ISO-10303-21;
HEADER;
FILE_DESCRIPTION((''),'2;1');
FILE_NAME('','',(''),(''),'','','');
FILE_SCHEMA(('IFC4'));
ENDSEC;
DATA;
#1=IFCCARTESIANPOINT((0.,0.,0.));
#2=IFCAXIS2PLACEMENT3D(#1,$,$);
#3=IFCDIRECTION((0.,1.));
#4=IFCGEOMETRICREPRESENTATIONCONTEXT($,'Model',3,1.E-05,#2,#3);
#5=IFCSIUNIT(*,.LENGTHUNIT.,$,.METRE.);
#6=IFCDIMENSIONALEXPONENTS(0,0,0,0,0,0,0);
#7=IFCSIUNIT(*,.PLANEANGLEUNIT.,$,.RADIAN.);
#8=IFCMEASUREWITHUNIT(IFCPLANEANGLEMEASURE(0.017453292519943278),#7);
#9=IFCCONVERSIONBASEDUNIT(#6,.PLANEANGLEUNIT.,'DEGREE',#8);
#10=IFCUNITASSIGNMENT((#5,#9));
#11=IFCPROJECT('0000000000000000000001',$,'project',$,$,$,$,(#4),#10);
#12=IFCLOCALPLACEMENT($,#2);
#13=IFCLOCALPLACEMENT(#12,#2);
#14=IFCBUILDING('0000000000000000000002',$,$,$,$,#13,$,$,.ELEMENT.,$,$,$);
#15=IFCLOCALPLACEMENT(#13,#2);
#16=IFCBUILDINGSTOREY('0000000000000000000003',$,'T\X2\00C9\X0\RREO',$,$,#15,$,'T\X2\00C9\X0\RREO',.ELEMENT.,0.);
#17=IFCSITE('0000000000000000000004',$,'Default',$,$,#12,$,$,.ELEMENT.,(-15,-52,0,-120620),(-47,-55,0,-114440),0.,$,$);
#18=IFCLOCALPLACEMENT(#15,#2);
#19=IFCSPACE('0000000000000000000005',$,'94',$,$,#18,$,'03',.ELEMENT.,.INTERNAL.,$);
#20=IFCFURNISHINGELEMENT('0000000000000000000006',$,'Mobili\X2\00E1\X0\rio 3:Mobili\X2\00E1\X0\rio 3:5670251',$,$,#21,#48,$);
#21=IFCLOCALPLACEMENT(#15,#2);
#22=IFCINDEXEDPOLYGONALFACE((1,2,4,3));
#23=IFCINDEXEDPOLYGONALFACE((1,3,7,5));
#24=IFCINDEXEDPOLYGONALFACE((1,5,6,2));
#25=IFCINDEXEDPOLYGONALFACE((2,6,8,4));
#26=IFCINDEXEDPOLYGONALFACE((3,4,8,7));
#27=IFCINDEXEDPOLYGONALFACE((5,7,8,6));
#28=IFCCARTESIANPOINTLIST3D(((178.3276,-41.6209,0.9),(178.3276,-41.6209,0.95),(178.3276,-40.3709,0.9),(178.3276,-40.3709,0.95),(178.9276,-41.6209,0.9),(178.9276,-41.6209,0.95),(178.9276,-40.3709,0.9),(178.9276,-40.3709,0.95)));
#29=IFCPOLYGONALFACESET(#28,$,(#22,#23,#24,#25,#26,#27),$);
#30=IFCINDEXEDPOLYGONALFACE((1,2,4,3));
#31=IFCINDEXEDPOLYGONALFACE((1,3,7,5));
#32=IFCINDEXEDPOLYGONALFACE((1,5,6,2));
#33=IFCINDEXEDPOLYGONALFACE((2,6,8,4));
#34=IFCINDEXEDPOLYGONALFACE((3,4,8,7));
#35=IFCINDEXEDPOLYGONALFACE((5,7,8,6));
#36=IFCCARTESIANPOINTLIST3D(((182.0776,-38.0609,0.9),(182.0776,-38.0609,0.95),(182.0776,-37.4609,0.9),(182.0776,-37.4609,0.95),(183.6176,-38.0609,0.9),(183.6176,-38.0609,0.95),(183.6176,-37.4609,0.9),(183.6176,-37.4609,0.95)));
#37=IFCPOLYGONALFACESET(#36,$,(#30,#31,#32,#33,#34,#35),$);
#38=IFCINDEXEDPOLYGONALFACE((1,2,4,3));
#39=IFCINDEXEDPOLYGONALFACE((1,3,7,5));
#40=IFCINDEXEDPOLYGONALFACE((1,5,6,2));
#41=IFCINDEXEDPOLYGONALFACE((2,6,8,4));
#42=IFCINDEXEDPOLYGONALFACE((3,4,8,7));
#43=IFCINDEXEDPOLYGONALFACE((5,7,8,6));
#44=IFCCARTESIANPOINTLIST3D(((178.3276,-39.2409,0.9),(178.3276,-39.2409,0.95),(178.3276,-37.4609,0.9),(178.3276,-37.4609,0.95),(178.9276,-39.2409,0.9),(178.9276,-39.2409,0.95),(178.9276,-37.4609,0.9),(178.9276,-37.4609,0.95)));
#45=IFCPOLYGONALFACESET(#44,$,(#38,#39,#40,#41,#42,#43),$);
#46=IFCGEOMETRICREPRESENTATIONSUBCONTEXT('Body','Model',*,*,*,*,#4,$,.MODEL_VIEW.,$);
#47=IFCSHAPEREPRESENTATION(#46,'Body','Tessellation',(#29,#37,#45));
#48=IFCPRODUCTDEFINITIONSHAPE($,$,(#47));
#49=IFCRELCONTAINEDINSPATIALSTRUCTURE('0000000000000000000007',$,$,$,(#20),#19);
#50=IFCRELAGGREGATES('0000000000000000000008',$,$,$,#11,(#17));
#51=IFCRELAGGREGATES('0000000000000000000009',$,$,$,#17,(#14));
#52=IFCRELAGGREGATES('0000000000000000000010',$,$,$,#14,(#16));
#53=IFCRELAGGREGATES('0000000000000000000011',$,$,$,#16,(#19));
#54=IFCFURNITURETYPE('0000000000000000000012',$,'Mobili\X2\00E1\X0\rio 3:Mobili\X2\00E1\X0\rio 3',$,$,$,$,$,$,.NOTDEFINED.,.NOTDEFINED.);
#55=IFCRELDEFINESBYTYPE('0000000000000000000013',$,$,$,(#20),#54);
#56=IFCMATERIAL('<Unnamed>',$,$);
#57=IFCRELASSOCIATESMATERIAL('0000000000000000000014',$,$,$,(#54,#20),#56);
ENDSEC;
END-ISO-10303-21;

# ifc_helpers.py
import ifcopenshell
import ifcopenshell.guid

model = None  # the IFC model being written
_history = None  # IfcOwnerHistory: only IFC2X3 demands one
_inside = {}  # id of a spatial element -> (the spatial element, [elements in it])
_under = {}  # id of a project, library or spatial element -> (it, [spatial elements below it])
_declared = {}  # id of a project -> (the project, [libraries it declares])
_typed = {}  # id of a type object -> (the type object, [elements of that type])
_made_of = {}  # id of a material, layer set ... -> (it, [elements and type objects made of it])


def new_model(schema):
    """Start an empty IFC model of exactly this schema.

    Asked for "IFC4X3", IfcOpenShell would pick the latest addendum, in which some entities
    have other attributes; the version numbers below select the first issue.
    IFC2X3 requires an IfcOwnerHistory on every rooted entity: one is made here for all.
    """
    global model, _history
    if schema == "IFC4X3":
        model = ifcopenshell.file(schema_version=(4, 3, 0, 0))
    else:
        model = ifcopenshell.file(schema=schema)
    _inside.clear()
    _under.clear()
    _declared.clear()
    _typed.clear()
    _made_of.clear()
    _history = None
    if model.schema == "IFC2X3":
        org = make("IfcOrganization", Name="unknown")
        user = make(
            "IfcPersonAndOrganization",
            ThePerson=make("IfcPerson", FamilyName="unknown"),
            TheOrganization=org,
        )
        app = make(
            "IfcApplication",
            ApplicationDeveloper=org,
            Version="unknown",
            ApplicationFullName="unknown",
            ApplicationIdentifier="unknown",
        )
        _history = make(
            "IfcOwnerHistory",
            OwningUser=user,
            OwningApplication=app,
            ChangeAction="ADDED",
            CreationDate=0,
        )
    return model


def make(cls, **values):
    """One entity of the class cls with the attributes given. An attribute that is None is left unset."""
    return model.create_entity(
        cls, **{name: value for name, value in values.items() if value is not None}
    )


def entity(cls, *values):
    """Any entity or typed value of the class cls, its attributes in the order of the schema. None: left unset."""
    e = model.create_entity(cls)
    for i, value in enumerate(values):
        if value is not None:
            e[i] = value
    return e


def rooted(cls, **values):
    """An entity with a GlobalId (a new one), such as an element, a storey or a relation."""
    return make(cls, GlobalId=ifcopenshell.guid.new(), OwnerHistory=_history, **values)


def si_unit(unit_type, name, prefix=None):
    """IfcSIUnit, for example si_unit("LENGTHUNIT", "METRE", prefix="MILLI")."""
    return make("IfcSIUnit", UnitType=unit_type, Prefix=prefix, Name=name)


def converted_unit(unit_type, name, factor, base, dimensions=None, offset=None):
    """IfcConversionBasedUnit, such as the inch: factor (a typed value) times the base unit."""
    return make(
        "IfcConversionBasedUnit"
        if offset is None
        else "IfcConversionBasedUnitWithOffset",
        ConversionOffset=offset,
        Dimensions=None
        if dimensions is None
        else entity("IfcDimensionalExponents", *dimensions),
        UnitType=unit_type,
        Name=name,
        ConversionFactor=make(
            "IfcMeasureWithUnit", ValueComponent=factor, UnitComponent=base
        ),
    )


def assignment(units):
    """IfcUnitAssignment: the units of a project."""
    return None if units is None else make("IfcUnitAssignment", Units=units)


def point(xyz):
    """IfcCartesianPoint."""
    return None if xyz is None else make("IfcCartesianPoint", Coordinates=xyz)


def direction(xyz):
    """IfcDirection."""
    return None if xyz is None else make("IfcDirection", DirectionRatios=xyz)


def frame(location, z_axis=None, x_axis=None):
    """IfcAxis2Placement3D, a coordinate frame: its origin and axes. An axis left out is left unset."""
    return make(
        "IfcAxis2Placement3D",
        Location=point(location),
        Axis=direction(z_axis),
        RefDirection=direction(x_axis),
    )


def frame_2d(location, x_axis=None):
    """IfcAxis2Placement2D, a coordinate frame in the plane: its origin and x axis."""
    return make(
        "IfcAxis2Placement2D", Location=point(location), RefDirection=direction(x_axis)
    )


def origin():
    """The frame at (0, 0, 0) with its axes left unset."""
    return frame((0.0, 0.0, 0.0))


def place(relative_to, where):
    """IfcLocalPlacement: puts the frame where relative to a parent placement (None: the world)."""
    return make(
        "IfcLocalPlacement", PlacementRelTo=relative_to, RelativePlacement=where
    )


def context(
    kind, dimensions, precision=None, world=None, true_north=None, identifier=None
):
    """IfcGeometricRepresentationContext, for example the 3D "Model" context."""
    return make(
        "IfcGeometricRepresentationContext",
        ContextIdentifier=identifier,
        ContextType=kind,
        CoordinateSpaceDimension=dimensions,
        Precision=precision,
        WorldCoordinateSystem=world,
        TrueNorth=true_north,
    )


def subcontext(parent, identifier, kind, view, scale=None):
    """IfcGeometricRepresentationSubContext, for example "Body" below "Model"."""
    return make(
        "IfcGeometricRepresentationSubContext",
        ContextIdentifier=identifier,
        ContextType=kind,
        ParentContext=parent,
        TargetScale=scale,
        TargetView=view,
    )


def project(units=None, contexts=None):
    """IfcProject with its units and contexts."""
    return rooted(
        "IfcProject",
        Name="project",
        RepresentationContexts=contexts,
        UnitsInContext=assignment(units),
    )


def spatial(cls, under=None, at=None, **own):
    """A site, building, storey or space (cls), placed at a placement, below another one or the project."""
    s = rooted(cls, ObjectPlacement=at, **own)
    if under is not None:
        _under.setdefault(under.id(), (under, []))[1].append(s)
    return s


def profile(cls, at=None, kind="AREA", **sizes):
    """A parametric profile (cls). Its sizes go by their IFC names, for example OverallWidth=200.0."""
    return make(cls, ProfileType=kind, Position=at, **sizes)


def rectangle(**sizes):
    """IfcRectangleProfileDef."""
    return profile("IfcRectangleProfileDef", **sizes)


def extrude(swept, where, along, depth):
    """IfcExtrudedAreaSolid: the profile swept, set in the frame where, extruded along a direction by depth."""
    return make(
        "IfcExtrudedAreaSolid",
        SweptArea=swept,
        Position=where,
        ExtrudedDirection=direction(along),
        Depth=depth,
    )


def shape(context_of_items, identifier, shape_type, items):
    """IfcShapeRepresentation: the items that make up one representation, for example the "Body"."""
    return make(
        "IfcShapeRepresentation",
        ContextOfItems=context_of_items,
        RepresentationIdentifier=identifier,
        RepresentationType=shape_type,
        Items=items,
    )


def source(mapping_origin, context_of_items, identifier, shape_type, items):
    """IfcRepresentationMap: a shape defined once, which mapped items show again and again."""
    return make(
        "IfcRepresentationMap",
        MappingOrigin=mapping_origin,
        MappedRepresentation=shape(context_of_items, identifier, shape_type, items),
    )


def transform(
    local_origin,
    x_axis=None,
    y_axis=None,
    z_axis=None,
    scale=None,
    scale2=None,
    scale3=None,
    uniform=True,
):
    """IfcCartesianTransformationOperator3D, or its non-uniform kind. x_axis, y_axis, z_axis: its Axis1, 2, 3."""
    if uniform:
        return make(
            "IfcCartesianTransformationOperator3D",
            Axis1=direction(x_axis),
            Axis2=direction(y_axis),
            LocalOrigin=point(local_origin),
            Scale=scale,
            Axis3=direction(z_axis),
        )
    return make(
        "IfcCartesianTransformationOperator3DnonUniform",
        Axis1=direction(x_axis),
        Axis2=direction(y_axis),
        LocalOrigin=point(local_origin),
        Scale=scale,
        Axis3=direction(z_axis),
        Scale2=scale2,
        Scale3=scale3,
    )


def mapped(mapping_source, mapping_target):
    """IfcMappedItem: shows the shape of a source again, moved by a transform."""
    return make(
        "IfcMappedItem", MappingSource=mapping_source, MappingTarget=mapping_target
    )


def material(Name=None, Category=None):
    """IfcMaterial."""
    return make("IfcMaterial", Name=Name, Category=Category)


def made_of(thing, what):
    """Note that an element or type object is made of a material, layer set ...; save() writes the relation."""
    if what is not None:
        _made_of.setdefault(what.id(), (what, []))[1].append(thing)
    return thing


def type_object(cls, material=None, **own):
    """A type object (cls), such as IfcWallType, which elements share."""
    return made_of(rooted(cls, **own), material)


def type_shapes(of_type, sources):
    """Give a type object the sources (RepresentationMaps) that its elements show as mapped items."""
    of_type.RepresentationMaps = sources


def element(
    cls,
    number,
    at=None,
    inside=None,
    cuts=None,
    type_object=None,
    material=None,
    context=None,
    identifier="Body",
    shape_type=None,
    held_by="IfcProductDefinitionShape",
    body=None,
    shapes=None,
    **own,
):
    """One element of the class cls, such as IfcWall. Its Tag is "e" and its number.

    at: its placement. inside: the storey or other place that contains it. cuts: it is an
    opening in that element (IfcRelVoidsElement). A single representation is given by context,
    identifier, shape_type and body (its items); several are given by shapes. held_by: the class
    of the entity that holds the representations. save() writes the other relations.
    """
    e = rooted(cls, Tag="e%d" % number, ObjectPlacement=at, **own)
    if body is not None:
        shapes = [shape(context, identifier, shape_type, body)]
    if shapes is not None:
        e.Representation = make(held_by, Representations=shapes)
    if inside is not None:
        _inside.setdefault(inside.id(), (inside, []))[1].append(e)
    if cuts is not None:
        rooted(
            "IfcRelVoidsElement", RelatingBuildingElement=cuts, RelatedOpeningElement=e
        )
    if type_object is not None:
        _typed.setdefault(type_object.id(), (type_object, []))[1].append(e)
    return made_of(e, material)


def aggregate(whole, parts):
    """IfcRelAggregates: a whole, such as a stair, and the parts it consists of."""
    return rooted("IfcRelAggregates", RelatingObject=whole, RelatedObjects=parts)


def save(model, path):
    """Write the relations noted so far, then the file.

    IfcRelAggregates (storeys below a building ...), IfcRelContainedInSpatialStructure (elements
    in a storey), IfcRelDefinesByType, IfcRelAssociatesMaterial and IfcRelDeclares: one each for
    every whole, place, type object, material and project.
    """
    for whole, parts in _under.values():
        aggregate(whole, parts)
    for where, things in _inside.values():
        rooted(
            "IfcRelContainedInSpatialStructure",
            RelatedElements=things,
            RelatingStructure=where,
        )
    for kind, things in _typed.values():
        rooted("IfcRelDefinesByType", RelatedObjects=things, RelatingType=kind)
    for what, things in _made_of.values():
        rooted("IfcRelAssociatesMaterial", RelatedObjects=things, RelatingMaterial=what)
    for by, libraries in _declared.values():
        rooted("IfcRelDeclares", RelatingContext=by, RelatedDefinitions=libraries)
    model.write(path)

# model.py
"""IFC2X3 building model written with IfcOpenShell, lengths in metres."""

from ifc_helpers import new_model, entity, si_unit, converted_unit, direction, frame, frame_2d, origin, place, context, subcontext, project, spatial, rectangle, extrude, source, transform, mapped, material, type_object, type_shapes, element, save


model = new_model("IFC2X3")

# Units and contexts
model_context = context("Model", 3, precision=1e-05, world=origin(), true_north=direction((0.0, 1.0)))
body_context = subcontext(model_context, "Body", "Model", "MODEL_VIEW")
ifc_project = project(units=[si_unit("LENGTHUNIT", "METRE"), converted_unit("PLANEANGLEUNIT", "DEGREE", entity("IfcPlaneAngleMeasure", 0.017453292519943278), si_unit("PLANEANGLEUNIT", "RADIAN"), dimensions=[0, 0, 0, 0, 0, 0, 0])], contexts=[model_context])

# Site, building, storey
site_placement = place(None, origin())
site = spatial("IfcSite", under=ifc_project, at=site_placement, Name="Default", CompositionType="ELEMENT", RefLatitude=(-15, -52, 0, -120620), RefLongitude=(-47, -55, 0, -114440), RefElevation=0.0)
building_placement = place(site_placement, origin())
building = spatial("IfcBuilding", under=site, at=building_placement, CompositionType="ELEMENT")
storey_placement = place(building_placement, origin())
storey = spatial("IfcBuildingStorey", under=building, at=storey_placement, Name="TÉRREO", LongName="TÉRREO", CompositionType="ELEMENT", Elevation=0.0)

# Shared definitions
ifc_material_1 = material(Name="<Unnamed>")

# Shared definitions
space_1_placement = place(storey_placement, origin())
space_1 = spatial("IfcSpace", under=storey, at=space_1_placement, Name="94", LongName="03", CompositionType="ELEMENT", InteriorOrExteriorSpace="INTERNAL")

# Furnishing element
furniture_type_1 = type_object("IfcFurnitureType", Name="Mobiliário 3:Mobiliário 3", AssemblyPlace="NOTDEFINED", material=ifc_material_1)
shared_shape_1 = source(origin(), body_context, "Body", "SweptSolid", [
    extrude(rectangle(XDim=1.25, YDim=0.6, at=frame_2d((0.0, 0.0), x_axis=(1.0, 0.0))), frame((178.6676, -40.9959, 0.9), z_axis=(0.0, 0.0, 1.0), x_axis=(0.0, 1.0, 0.0)), (0.0, 0.0, 1.0), 0.05),
    extrude(rectangle(XDim=1.54, YDim=0.6, at=frame_2d((0.0, 0.0), x_axis=(1.0, 0.0))), frame((182.8876, -37.7609, 0.9), z_axis=(0.0, 0.0, 1.0), x_axis=(-1.0, 0.0, 0.0)), (0.0, 0.0, 1.0), 0.05),
    extrude(rectangle(XDim=1.78, YDim=0.6, at=frame_2d((0.0, 0.0), x_axis=(1.0, 0.0))), frame((178.6676, -38.3509, 0.9), z_axis=(0.0, 0.0, 1.0), x_axis=(0.0, 1.0, 0.0)), (0.0, 0.0, 1.0), 0.05),
])
type_shapes(furniture_type_1, [shared_shape_1])
furnishing_1_placement = place(space_1_placement, frame((-0.04, 0.0, 0.0)))
element("IfcFurnishingElement", 1, at=furnishing_1_placement, inside=space_1, type_object=furniture_type_1, material=ifc_material_1, Name="Mobiliário 3:Mobiliário 3:5670251", context=body_context, shape_type="MappedRepresentation", body=[
    mapped(shared_shape_1, transform((0.0, 0.0, 0.0), scale=1.0)),
])

save(model, "model.ifc")
